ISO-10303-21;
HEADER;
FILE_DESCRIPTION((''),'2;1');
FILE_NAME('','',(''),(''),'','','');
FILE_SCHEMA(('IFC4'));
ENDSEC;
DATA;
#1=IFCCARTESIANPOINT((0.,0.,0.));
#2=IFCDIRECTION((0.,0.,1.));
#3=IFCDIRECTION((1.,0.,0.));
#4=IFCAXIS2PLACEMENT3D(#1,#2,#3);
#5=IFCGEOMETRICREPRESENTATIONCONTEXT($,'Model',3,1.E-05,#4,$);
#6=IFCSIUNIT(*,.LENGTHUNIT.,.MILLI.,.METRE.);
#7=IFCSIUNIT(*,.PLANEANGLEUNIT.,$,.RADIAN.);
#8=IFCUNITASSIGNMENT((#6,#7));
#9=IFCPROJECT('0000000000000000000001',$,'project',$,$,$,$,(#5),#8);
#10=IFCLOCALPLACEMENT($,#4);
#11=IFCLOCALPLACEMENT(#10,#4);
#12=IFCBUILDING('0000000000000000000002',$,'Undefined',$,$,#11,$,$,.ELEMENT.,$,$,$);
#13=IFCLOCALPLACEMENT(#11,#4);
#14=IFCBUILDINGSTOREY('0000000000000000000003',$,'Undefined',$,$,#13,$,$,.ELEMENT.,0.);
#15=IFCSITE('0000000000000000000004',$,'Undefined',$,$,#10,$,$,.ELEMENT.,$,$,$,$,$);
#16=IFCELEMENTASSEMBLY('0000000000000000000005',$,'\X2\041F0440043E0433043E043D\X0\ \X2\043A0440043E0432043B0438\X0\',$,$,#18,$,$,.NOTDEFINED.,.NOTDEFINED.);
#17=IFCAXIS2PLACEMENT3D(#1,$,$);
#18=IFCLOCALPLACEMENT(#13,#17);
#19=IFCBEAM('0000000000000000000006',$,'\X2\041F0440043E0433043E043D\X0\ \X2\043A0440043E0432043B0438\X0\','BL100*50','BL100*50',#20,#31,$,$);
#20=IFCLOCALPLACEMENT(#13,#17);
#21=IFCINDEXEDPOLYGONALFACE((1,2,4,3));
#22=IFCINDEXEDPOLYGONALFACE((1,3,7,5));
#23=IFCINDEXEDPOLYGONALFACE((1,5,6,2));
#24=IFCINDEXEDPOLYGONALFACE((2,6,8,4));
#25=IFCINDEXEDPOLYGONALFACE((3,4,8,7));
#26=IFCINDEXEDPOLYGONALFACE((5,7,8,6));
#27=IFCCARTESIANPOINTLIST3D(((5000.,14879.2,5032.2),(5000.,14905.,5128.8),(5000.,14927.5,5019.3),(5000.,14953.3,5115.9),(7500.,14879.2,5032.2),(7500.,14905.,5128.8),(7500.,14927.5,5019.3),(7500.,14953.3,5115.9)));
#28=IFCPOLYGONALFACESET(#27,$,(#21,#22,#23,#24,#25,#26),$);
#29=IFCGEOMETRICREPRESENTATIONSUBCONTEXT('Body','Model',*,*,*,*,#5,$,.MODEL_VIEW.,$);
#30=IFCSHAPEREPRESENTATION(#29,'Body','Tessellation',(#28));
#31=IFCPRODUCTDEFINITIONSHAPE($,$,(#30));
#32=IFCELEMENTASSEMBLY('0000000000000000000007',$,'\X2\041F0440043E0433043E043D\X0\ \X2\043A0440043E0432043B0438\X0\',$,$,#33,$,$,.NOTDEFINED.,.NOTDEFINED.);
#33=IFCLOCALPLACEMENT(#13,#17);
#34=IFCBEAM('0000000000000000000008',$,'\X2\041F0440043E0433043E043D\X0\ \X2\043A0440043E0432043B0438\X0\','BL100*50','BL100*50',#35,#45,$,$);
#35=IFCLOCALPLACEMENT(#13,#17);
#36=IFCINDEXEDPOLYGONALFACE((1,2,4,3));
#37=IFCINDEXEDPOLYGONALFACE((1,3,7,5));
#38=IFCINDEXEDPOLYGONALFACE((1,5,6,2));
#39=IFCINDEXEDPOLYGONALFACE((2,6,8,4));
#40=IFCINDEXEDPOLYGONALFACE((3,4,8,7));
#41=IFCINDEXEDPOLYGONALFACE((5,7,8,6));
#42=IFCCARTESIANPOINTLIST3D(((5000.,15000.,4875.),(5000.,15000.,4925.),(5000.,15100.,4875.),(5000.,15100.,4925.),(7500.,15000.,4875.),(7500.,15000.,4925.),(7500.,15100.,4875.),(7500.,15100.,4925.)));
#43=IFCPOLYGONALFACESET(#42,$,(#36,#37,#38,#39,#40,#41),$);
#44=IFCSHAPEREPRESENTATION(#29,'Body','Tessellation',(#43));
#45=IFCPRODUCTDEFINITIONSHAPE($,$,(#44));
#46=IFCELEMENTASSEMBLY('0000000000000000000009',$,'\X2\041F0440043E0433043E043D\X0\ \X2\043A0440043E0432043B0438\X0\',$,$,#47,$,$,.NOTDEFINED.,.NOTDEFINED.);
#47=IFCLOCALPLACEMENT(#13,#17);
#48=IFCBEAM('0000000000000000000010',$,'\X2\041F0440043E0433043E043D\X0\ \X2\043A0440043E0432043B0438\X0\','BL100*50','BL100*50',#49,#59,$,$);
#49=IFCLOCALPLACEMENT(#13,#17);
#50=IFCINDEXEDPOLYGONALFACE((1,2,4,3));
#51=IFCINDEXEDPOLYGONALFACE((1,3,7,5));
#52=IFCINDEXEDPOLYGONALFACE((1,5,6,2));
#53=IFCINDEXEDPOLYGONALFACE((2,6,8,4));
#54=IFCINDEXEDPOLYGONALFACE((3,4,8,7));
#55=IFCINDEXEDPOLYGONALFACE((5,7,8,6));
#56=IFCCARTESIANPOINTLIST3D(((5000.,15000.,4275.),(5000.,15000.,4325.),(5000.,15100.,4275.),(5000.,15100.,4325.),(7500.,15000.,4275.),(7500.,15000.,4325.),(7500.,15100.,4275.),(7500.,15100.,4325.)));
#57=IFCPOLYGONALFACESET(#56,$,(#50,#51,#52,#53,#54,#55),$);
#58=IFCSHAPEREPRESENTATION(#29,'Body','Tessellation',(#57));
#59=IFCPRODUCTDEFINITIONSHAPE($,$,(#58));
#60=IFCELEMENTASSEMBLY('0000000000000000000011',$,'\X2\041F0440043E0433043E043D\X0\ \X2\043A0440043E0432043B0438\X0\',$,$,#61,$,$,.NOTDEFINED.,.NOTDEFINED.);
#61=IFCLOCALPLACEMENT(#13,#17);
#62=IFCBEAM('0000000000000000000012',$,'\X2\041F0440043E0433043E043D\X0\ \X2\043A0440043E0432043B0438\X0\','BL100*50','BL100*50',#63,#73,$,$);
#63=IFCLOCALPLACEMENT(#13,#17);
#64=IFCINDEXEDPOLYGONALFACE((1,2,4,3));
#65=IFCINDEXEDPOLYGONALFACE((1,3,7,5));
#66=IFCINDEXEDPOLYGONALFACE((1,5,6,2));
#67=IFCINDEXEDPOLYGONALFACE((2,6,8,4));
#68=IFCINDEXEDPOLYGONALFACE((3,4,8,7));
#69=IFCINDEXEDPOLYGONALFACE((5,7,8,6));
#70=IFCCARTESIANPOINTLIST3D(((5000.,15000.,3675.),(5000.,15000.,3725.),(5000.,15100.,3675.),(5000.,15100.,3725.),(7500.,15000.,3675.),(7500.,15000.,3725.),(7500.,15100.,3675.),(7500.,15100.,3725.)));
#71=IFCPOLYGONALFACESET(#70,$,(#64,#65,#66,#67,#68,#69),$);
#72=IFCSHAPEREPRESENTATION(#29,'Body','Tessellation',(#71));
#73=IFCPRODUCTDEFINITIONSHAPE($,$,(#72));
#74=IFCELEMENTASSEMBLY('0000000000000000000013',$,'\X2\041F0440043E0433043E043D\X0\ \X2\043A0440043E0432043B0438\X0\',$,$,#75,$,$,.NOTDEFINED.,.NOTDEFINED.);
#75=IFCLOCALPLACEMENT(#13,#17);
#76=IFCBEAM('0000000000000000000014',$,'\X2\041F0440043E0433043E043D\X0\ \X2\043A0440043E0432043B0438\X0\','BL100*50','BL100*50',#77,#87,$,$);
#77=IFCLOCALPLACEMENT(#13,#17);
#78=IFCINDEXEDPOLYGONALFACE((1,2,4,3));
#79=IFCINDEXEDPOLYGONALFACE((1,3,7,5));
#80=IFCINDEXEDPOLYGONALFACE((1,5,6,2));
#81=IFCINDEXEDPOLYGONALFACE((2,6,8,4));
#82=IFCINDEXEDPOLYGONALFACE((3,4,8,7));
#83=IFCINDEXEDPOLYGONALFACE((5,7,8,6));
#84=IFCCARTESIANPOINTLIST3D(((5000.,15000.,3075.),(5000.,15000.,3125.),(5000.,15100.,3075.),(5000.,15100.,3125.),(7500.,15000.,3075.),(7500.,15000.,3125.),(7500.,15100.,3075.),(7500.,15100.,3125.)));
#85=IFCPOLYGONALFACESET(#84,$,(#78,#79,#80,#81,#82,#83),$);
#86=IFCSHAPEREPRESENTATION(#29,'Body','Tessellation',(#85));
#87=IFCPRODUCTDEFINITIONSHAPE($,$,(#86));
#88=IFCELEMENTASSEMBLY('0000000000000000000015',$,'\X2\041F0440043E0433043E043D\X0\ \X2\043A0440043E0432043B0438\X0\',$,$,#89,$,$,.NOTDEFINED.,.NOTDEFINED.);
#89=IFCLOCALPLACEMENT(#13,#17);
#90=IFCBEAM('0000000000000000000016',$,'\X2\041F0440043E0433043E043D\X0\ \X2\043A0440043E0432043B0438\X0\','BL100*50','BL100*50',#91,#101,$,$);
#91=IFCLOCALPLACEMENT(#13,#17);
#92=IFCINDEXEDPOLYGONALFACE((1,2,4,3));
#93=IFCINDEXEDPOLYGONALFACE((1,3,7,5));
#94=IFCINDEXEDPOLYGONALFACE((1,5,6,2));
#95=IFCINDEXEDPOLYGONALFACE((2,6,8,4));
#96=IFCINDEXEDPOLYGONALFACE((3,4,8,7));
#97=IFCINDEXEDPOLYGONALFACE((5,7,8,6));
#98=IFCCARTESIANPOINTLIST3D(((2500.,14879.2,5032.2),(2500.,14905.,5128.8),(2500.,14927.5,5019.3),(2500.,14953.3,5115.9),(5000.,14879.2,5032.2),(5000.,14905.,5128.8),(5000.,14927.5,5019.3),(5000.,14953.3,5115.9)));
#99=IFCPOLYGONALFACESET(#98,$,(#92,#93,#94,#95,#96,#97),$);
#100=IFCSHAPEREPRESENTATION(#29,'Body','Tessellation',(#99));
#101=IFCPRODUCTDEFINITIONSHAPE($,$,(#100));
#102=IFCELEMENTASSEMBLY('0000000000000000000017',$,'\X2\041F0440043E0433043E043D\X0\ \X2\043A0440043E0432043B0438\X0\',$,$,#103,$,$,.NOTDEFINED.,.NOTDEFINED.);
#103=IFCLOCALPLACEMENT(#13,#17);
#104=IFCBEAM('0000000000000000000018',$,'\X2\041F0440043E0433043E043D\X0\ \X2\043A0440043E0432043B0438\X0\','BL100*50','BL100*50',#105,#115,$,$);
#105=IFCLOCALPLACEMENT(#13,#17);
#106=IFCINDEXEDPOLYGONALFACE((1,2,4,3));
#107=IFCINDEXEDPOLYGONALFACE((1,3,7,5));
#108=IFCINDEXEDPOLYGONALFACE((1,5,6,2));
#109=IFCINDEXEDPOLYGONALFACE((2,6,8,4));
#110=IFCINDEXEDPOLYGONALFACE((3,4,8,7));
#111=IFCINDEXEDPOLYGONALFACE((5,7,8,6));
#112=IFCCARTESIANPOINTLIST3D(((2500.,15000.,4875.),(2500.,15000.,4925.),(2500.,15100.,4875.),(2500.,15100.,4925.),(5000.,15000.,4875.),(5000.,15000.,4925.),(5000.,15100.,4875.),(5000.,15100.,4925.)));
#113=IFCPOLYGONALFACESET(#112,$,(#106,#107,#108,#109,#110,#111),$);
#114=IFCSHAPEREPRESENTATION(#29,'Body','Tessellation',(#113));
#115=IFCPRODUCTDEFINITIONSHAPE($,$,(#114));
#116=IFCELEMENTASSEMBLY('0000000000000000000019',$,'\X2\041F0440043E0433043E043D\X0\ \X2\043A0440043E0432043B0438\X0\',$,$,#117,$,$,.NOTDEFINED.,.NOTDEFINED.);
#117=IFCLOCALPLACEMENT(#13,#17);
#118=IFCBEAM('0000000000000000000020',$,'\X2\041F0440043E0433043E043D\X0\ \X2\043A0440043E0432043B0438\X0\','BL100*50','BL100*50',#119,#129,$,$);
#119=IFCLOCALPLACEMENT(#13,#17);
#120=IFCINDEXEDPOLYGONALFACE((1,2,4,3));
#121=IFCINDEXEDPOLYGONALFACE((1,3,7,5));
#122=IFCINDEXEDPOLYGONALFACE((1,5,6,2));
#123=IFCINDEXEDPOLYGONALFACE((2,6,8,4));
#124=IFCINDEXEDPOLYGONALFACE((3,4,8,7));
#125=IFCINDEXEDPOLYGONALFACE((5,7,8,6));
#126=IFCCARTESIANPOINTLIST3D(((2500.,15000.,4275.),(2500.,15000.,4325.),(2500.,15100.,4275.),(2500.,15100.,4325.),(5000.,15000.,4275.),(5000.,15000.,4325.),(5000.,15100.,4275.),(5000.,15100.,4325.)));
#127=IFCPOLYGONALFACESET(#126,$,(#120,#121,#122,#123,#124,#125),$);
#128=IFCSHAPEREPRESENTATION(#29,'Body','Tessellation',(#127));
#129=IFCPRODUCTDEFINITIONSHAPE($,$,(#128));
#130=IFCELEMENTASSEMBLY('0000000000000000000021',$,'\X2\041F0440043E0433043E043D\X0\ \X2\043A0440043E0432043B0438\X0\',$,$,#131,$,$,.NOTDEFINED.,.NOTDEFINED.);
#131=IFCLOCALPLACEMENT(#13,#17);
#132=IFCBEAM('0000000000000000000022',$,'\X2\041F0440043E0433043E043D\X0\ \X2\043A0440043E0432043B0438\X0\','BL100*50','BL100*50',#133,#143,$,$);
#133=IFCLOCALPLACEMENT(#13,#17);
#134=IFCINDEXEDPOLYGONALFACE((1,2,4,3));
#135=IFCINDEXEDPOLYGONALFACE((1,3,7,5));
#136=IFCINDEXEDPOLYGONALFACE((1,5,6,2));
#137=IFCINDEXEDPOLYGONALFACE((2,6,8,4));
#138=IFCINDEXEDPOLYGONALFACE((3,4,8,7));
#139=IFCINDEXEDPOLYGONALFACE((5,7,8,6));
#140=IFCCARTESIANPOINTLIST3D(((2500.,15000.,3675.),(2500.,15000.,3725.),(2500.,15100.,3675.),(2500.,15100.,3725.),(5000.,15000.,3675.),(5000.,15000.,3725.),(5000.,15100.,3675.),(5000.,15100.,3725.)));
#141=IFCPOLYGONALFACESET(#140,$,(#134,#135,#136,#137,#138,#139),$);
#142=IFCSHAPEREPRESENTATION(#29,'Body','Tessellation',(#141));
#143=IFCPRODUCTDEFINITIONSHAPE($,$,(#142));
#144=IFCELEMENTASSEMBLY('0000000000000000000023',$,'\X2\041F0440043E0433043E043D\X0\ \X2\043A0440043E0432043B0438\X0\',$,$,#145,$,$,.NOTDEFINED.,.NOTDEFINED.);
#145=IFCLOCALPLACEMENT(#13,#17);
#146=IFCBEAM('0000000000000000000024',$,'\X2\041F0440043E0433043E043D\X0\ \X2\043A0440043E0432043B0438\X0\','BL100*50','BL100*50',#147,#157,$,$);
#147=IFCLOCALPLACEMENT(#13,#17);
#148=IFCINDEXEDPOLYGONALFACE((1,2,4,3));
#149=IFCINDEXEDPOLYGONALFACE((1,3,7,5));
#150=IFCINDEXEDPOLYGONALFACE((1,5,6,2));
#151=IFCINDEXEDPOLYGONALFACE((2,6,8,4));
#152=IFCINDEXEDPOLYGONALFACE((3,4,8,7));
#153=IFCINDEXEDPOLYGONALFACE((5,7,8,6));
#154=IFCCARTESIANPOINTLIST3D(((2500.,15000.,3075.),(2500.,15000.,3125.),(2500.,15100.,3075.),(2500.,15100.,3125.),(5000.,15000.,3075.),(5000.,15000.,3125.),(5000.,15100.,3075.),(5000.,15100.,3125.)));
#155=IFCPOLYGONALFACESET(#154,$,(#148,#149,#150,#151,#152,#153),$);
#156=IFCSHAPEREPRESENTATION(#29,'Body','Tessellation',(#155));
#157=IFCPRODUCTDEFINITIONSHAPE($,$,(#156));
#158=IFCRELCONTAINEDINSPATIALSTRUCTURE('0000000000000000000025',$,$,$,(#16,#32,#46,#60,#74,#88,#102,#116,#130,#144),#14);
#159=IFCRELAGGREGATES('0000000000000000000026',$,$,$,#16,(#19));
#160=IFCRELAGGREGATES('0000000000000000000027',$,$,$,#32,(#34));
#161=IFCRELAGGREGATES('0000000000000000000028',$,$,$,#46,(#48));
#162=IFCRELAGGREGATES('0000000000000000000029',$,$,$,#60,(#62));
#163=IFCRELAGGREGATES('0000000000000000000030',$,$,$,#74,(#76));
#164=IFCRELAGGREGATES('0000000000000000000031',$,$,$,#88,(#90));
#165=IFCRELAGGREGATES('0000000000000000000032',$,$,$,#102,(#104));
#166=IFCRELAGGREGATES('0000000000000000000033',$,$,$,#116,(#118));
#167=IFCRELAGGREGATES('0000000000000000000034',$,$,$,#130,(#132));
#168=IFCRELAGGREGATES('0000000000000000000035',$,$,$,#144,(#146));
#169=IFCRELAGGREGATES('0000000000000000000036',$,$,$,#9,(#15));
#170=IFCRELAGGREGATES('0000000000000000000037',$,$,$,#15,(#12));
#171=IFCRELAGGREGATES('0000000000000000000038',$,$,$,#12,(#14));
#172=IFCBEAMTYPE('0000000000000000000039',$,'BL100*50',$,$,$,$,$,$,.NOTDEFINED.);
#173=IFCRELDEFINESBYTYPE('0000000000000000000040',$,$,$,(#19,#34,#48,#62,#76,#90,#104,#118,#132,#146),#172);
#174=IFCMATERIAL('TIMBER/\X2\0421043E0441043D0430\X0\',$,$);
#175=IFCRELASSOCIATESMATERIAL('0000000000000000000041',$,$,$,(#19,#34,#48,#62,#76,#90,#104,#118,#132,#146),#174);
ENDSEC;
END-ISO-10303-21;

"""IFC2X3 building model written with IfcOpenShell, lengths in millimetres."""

from ifc_helpers import new_model, si_unit, frame, origin_with_axes, origin_2d_with_axis, place, context, subcontext, project, spatial, rectangle, extrude, material, type_object, element, aggregate, save


model = new_model("IFC2X3")

# Units and contexts
model_context = context("Model", 3, precision=1e-05, world=origin_with_axes())
body_context = subcontext(model_context, "Body", "Model", "MODEL_VIEW")
ifc_project = project(units=[si_unit("LENGTHUNIT", "METRE", prefix="MILLI"), si_unit("PLANEANGLEUNIT", "RADIAN")], contexts=[model_context])

# Site, building, storey
site_placement = place(None, origin_with_axes())
site = spatial("IfcSite", under=ifc_project, at=site_placement, Name="Undefined", CompositionType="ELEMENT")
building_placement = place(site_placement, origin_with_axes())
building = spatial("IfcBuilding", under=site, at=building_placement, Name="Undefined", CompositionType="ELEMENT")
storey_placement = place(building_placement, origin_with_axes())
storey = spatial("IfcBuildingStorey", under=building, at=storey_placement, Name="Undefined", CompositionType="ELEMENT", Elevation=0.0)

# Element assemblies, beams
assembly_1_placement = place(storey_placement, origin_with_axes())
assembly_1 = element("IfcElementAssembly", 1, at=assembly_1_placement, inside=storey, Name="Прогон кровли", AssemblyPlace="NOTDEFINED", PredefinedType="NOTDEFINED")
ifc_material_1 = material(Name="TIMBER/Сосна")
beam_type_1 = type_object("IfcBeamType", Name="BL100*50", PredefinedType="NOTDEFINED")
beam_1_placement = place(assembly_1_placement, frame((5000.0, 14916.3, 5074.1), z_axis=(0.0, -0.257663, -0.966235), x_axis=(1.0, 0.0, 0.0)))
beam_1 = element("IfcBeam", 2, at=beam_1_placement, type_object=beam_type_1, material=ifc_material_1, Name="Прогон кровли", Description="BL100*50", ObjectType="BL100*50", context=body_context, shape_type="SweptSolid", body=[
    extrude(rectangle(XDim=50.0, YDim=100.0, at=origin_2d_with_axis()), frame((2500.0, 0.0, 0.0), z_axis=(-1.0, 0.0, 0.0), x_axis=(0.0, -1.0, 0.0)), (0.0, 0.0, 1.0), 2500.0),
])
aggregate(assembly_1, [beam_1])
assembly_2_placement = place(storey_placement, origin_with_axes())
assembly_2 = element("IfcElementAssembly", 3, at=assembly_2_placement, inside=storey, Name="Прогон кровли", AssemblyPlace="NOTDEFINED", PredefinedType="NOTDEFINED")
beam_2_placement = place(assembly_2_placement, frame((5000.0, 15050.0, 4900.0), z_axis=(0.0, 1.0, 0.0), x_axis=(1.0, 0.0, 0.0)))
beam_2 = element("IfcBeam", 4, at=beam_2_placement, type_object=beam_type_1, material=ifc_material_1, Name="Прогон кровли", Description="BL100*50", ObjectType="BL100*50", context=body_context, shape_type="SweptSolid", body=[
    extrude(rectangle(XDim=50.0, YDim=100.0, at=origin_2d_with_axis()), frame((2500.0, 0.0, 0.0), z_axis=(-1.0, 0.0, 0.0), x_axis=(0.0, -1.0, 0.0)), (0.0, 0.0, 1.0), 2500.0),
])
aggregate(assembly_2, [beam_2])
assembly_3_placement = place(storey_placement, origin_with_axes())
assembly_3 = element("IfcElementAssembly", 5, at=assembly_3_placement, inside=storey, Name="Прогон кровли", AssemblyPlace="NOTDEFINED", PredefinedType="NOTDEFINED")
beam_3_placement = place(assembly_3_placement, frame((5000.0, 15050.0, 4300.0), z_axis=(0.0, 1.0, 0.0), x_axis=(1.0, 0.0, 0.0)))
beam_3 = element("IfcBeam", 6, at=beam_3_placement, type_object=beam_type_1, material=ifc_material_1, Name="Прогон кровли", Description="BL100*50", ObjectType="BL100*50", context=body_context, shape_type="SweptSolid", body=[
    extrude(rectangle(XDim=50.0, YDim=100.0, at=origin_2d_with_axis()), frame((2500.0, 0.0, 0.0), z_axis=(-1.0, 0.0, 0.0), x_axis=(0.0, -1.0, 0.0)), (0.0, 0.0, 1.0), 2500.0),
])
aggregate(assembly_3, [beam_3])
assembly_4_placement = place(storey_placement, origin_with_axes())
assembly_4 = element("IfcElementAssembly", 7, at=assembly_4_placement, inside=storey, Name="Прогон кровли", AssemblyPlace="NOTDEFINED", PredefinedType="NOTDEFINED")
beam_4_placement = place(assembly_4_placement, frame((5000.0, 15050.0, 3700.0), z_axis=(0.0, 1.0, 0.0), x_axis=(1.0, 0.0, 0.0)))
beam_4 = element("IfcBeam", 8, at=beam_4_placement, type_object=beam_type_1, material=ifc_material_1, Name="Прогон кровли", Description="BL100*50", ObjectType="BL100*50", context=body_context, shape_type="SweptSolid", body=[
    extrude(rectangle(XDim=50.0, YDim=100.0, at=origin_2d_with_axis()), frame((2500.0, 0.0, 0.0), z_axis=(-1.0, 0.0, 0.0), x_axis=(0.0, -1.0, 0.0)), (0.0, 0.0, 1.0), 2500.0),
])
aggregate(assembly_4, [beam_4])
assembly_5_placement = place(storey_placement, origin_with_axes())
assembly_5 = element("IfcElementAssembly", 9, at=assembly_5_placement, inside=storey, Name="Прогон кровли", AssemblyPlace="NOTDEFINED", PredefinedType="NOTDEFINED")
beam_5_placement = place(assembly_5_placement, frame((5000.0, 15050.0, 3100.0), z_axis=(0.0, 1.0, 0.0), x_axis=(1.0, 0.0, 0.0)))
beam_5 = element("IfcBeam", 10, at=beam_5_placement, type_object=beam_type_1, material=ifc_material_1, Name="Прогон кровли", Description="BL100*50", ObjectType="BL100*50", context=body_context, shape_type="SweptSolid", body=[
    extrude(rectangle(XDim=50.0, YDim=100.0, at=origin_2d_with_axis()), frame((2500.0, 0.0, 0.0), z_axis=(-1.0, 0.0, 0.0), x_axis=(0.0, -1.0, 0.0)), (0.0, 0.0, 1.0), 2500.0),
])
aggregate(assembly_5, [beam_5])
assembly_6_placement = place(storey_placement, origin_with_axes())
assembly_6 = element("IfcElementAssembly", 11, at=assembly_6_placement, inside=storey, Name="Прогон кровли", AssemblyPlace="NOTDEFINED", PredefinedType="NOTDEFINED")
beam_6_placement = place(assembly_6_placement, frame((2500.0, 14916.3, 5074.1), z_axis=(0.0, -0.257663, -0.966235), x_axis=(1.0, 0.0, 0.0)))
beam_6 = element("IfcBeam", 12, at=beam_6_placement, type_object=beam_type_1, material=ifc_material_1, Name="Прогон кровли", Description="BL100*50", ObjectType="BL100*50", context=body_context, shape_type="SweptSolid", body=[
    extrude(rectangle(XDim=50.0, YDim=100.0, at=origin_2d_with_axis()), frame((2500.0, 0.0, 0.0), z_axis=(-1.0, 0.0, 0.0), x_axis=(0.0, -1.0, 0.0)), (0.0, 0.0, 1.0), 2500.0),
])
aggregate(assembly_6, [beam_6])
assembly_7_placement = place(storey_placement, origin_with_axes())
assembly_7 = element("IfcElementAssembly", 13, at=assembly_7_placement, inside=storey, Name="Прогон кровли", AssemblyPlace="NOTDEFINED", PredefinedType="NOTDEFINED")
beam_7_placement = place(assembly_7_placement, frame((2500.0, 15050.0, 4900.0), z_axis=(0.0, 1.0, 0.0), x_axis=(1.0, 0.0, 0.0)))
beam_7 = element("IfcBeam", 14, at=beam_7_placement, type_object=beam_type_1, material=ifc_material_1, Name="Прогон кровли", Description="BL100*50", ObjectType="BL100*50", context=body_context, shape_type="SweptSolid", body=[
    extrude(rectangle(XDim=50.0, YDim=100.0, at=origin_2d_with_axis()), frame((2500.0, 0.0, 0.0), z_axis=(-1.0, 0.0, 0.0), x_axis=(0.0, -1.0, 0.0)), (0.0, 0.0, 1.0), 2500.0),
])
aggregate(assembly_7, [beam_7])
assembly_8_placement = place(storey_placement, origin_with_axes())
assembly_8 = element("IfcElementAssembly", 15, at=assembly_8_placement, inside=storey, Name="Прогон кровли", AssemblyPlace="NOTDEFINED", PredefinedType="NOTDEFINED")
beam_8_placement = place(assembly_8_placement, frame((2500.0, 15050.0, 4300.0), z_axis=(0.0, 1.0, 0.0), x_axis=(1.0, 0.0, 0.0)))
beam_8 = element("IfcBeam", 16, at=beam_8_placement, type_object=beam_type_1, material=ifc_material_1, Name="Прогон кровли", Description="BL100*50", ObjectType="BL100*50", context=body_context, shape_type="SweptSolid", body=[
    extrude(rectangle(XDim=50.0, YDim=100.0, at=origin_2d_with_axis()), frame((2500.0, 0.0, 0.0), z_axis=(-1.0, 0.0, 0.0), x_axis=(0.0, -1.0, 0.0)), (0.0, 0.0, 1.0), 2500.0),
])
aggregate(assembly_8, [beam_8])
assembly_9_placement = place(storey_placement, origin_with_axes())
assembly_9 = element("IfcElementAssembly", 17, at=assembly_9_placement, inside=storey, Name="Прогон кровли", AssemblyPlace="NOTDEFINED", PredefinedType="NOTDEFINED")
beam_9_placement = place(assembly_9_placement, frame((2500.0, 15050.0, 3700.0), z_axis=(0.0, 1.0, 0.0), x_axis=(1.0, 0.0, 0.0)))
beam_9 = element("IfcBeam", 18, at=beam_9_placement, type_object=beam_type_1, material=ifc_material_1, Name="Прогон кровли", Description="BL100*50", ObjectType="BL100*50", context=body_context, shape_type="SweptSolid", body=[
    extrude(rectangle(XDim=50.0, YDim=100.0, at=origin_2d_with_axis()), frame((2500.0, 0.0, 0.0), z_axis=(-1.0, 0.0, 0.0), x_axis=(0.0, -1.0, 0.0)), (0.0, 0.0, 1.0), 2500.0),
])
aggregate(assembly_9, [beam_9])
assembly_10_placement = place(storey_placement, origin_with_axes())
assembly_10 = element("IfcElementAssembly", 19, at=assembly_10_placement, inside=storey, Name="Прогон кровли", AssemblyPlace="NOTDEFINED", PredefinedType="NOTDEFINED")
beam_10_placement = place(assembly_10_placement, frame((2500.0, 15050.0, 3100.0), z_axis=(0.0, 1.0, 0.0), x_axis=(1.0, 0.0, 0.0)))
beam_10 = element("IfcBeam", 20, at=beam_10_placement, type_object=beam_type_1, material=ifc_material_1, Name="Прогон кровли", Description="BL100*50", ObjectType="BL100*50", context=body_context, shape_type="SweptSolid", body=[
    extrude(rectangle(XDim=50.0, YDim=100.0, at=origin_2d_with_axis()), frame((2500.0, 0.0, 0.0), z_axis=(-1.0, 0.0, 0.0), x_axis=(0.0, -1.0, 0.0)), (0.0, 0.0, 1.0), 2500.0),
])
aggregate(assembly_10, [beam_10])

save(model, "model.ifc")
